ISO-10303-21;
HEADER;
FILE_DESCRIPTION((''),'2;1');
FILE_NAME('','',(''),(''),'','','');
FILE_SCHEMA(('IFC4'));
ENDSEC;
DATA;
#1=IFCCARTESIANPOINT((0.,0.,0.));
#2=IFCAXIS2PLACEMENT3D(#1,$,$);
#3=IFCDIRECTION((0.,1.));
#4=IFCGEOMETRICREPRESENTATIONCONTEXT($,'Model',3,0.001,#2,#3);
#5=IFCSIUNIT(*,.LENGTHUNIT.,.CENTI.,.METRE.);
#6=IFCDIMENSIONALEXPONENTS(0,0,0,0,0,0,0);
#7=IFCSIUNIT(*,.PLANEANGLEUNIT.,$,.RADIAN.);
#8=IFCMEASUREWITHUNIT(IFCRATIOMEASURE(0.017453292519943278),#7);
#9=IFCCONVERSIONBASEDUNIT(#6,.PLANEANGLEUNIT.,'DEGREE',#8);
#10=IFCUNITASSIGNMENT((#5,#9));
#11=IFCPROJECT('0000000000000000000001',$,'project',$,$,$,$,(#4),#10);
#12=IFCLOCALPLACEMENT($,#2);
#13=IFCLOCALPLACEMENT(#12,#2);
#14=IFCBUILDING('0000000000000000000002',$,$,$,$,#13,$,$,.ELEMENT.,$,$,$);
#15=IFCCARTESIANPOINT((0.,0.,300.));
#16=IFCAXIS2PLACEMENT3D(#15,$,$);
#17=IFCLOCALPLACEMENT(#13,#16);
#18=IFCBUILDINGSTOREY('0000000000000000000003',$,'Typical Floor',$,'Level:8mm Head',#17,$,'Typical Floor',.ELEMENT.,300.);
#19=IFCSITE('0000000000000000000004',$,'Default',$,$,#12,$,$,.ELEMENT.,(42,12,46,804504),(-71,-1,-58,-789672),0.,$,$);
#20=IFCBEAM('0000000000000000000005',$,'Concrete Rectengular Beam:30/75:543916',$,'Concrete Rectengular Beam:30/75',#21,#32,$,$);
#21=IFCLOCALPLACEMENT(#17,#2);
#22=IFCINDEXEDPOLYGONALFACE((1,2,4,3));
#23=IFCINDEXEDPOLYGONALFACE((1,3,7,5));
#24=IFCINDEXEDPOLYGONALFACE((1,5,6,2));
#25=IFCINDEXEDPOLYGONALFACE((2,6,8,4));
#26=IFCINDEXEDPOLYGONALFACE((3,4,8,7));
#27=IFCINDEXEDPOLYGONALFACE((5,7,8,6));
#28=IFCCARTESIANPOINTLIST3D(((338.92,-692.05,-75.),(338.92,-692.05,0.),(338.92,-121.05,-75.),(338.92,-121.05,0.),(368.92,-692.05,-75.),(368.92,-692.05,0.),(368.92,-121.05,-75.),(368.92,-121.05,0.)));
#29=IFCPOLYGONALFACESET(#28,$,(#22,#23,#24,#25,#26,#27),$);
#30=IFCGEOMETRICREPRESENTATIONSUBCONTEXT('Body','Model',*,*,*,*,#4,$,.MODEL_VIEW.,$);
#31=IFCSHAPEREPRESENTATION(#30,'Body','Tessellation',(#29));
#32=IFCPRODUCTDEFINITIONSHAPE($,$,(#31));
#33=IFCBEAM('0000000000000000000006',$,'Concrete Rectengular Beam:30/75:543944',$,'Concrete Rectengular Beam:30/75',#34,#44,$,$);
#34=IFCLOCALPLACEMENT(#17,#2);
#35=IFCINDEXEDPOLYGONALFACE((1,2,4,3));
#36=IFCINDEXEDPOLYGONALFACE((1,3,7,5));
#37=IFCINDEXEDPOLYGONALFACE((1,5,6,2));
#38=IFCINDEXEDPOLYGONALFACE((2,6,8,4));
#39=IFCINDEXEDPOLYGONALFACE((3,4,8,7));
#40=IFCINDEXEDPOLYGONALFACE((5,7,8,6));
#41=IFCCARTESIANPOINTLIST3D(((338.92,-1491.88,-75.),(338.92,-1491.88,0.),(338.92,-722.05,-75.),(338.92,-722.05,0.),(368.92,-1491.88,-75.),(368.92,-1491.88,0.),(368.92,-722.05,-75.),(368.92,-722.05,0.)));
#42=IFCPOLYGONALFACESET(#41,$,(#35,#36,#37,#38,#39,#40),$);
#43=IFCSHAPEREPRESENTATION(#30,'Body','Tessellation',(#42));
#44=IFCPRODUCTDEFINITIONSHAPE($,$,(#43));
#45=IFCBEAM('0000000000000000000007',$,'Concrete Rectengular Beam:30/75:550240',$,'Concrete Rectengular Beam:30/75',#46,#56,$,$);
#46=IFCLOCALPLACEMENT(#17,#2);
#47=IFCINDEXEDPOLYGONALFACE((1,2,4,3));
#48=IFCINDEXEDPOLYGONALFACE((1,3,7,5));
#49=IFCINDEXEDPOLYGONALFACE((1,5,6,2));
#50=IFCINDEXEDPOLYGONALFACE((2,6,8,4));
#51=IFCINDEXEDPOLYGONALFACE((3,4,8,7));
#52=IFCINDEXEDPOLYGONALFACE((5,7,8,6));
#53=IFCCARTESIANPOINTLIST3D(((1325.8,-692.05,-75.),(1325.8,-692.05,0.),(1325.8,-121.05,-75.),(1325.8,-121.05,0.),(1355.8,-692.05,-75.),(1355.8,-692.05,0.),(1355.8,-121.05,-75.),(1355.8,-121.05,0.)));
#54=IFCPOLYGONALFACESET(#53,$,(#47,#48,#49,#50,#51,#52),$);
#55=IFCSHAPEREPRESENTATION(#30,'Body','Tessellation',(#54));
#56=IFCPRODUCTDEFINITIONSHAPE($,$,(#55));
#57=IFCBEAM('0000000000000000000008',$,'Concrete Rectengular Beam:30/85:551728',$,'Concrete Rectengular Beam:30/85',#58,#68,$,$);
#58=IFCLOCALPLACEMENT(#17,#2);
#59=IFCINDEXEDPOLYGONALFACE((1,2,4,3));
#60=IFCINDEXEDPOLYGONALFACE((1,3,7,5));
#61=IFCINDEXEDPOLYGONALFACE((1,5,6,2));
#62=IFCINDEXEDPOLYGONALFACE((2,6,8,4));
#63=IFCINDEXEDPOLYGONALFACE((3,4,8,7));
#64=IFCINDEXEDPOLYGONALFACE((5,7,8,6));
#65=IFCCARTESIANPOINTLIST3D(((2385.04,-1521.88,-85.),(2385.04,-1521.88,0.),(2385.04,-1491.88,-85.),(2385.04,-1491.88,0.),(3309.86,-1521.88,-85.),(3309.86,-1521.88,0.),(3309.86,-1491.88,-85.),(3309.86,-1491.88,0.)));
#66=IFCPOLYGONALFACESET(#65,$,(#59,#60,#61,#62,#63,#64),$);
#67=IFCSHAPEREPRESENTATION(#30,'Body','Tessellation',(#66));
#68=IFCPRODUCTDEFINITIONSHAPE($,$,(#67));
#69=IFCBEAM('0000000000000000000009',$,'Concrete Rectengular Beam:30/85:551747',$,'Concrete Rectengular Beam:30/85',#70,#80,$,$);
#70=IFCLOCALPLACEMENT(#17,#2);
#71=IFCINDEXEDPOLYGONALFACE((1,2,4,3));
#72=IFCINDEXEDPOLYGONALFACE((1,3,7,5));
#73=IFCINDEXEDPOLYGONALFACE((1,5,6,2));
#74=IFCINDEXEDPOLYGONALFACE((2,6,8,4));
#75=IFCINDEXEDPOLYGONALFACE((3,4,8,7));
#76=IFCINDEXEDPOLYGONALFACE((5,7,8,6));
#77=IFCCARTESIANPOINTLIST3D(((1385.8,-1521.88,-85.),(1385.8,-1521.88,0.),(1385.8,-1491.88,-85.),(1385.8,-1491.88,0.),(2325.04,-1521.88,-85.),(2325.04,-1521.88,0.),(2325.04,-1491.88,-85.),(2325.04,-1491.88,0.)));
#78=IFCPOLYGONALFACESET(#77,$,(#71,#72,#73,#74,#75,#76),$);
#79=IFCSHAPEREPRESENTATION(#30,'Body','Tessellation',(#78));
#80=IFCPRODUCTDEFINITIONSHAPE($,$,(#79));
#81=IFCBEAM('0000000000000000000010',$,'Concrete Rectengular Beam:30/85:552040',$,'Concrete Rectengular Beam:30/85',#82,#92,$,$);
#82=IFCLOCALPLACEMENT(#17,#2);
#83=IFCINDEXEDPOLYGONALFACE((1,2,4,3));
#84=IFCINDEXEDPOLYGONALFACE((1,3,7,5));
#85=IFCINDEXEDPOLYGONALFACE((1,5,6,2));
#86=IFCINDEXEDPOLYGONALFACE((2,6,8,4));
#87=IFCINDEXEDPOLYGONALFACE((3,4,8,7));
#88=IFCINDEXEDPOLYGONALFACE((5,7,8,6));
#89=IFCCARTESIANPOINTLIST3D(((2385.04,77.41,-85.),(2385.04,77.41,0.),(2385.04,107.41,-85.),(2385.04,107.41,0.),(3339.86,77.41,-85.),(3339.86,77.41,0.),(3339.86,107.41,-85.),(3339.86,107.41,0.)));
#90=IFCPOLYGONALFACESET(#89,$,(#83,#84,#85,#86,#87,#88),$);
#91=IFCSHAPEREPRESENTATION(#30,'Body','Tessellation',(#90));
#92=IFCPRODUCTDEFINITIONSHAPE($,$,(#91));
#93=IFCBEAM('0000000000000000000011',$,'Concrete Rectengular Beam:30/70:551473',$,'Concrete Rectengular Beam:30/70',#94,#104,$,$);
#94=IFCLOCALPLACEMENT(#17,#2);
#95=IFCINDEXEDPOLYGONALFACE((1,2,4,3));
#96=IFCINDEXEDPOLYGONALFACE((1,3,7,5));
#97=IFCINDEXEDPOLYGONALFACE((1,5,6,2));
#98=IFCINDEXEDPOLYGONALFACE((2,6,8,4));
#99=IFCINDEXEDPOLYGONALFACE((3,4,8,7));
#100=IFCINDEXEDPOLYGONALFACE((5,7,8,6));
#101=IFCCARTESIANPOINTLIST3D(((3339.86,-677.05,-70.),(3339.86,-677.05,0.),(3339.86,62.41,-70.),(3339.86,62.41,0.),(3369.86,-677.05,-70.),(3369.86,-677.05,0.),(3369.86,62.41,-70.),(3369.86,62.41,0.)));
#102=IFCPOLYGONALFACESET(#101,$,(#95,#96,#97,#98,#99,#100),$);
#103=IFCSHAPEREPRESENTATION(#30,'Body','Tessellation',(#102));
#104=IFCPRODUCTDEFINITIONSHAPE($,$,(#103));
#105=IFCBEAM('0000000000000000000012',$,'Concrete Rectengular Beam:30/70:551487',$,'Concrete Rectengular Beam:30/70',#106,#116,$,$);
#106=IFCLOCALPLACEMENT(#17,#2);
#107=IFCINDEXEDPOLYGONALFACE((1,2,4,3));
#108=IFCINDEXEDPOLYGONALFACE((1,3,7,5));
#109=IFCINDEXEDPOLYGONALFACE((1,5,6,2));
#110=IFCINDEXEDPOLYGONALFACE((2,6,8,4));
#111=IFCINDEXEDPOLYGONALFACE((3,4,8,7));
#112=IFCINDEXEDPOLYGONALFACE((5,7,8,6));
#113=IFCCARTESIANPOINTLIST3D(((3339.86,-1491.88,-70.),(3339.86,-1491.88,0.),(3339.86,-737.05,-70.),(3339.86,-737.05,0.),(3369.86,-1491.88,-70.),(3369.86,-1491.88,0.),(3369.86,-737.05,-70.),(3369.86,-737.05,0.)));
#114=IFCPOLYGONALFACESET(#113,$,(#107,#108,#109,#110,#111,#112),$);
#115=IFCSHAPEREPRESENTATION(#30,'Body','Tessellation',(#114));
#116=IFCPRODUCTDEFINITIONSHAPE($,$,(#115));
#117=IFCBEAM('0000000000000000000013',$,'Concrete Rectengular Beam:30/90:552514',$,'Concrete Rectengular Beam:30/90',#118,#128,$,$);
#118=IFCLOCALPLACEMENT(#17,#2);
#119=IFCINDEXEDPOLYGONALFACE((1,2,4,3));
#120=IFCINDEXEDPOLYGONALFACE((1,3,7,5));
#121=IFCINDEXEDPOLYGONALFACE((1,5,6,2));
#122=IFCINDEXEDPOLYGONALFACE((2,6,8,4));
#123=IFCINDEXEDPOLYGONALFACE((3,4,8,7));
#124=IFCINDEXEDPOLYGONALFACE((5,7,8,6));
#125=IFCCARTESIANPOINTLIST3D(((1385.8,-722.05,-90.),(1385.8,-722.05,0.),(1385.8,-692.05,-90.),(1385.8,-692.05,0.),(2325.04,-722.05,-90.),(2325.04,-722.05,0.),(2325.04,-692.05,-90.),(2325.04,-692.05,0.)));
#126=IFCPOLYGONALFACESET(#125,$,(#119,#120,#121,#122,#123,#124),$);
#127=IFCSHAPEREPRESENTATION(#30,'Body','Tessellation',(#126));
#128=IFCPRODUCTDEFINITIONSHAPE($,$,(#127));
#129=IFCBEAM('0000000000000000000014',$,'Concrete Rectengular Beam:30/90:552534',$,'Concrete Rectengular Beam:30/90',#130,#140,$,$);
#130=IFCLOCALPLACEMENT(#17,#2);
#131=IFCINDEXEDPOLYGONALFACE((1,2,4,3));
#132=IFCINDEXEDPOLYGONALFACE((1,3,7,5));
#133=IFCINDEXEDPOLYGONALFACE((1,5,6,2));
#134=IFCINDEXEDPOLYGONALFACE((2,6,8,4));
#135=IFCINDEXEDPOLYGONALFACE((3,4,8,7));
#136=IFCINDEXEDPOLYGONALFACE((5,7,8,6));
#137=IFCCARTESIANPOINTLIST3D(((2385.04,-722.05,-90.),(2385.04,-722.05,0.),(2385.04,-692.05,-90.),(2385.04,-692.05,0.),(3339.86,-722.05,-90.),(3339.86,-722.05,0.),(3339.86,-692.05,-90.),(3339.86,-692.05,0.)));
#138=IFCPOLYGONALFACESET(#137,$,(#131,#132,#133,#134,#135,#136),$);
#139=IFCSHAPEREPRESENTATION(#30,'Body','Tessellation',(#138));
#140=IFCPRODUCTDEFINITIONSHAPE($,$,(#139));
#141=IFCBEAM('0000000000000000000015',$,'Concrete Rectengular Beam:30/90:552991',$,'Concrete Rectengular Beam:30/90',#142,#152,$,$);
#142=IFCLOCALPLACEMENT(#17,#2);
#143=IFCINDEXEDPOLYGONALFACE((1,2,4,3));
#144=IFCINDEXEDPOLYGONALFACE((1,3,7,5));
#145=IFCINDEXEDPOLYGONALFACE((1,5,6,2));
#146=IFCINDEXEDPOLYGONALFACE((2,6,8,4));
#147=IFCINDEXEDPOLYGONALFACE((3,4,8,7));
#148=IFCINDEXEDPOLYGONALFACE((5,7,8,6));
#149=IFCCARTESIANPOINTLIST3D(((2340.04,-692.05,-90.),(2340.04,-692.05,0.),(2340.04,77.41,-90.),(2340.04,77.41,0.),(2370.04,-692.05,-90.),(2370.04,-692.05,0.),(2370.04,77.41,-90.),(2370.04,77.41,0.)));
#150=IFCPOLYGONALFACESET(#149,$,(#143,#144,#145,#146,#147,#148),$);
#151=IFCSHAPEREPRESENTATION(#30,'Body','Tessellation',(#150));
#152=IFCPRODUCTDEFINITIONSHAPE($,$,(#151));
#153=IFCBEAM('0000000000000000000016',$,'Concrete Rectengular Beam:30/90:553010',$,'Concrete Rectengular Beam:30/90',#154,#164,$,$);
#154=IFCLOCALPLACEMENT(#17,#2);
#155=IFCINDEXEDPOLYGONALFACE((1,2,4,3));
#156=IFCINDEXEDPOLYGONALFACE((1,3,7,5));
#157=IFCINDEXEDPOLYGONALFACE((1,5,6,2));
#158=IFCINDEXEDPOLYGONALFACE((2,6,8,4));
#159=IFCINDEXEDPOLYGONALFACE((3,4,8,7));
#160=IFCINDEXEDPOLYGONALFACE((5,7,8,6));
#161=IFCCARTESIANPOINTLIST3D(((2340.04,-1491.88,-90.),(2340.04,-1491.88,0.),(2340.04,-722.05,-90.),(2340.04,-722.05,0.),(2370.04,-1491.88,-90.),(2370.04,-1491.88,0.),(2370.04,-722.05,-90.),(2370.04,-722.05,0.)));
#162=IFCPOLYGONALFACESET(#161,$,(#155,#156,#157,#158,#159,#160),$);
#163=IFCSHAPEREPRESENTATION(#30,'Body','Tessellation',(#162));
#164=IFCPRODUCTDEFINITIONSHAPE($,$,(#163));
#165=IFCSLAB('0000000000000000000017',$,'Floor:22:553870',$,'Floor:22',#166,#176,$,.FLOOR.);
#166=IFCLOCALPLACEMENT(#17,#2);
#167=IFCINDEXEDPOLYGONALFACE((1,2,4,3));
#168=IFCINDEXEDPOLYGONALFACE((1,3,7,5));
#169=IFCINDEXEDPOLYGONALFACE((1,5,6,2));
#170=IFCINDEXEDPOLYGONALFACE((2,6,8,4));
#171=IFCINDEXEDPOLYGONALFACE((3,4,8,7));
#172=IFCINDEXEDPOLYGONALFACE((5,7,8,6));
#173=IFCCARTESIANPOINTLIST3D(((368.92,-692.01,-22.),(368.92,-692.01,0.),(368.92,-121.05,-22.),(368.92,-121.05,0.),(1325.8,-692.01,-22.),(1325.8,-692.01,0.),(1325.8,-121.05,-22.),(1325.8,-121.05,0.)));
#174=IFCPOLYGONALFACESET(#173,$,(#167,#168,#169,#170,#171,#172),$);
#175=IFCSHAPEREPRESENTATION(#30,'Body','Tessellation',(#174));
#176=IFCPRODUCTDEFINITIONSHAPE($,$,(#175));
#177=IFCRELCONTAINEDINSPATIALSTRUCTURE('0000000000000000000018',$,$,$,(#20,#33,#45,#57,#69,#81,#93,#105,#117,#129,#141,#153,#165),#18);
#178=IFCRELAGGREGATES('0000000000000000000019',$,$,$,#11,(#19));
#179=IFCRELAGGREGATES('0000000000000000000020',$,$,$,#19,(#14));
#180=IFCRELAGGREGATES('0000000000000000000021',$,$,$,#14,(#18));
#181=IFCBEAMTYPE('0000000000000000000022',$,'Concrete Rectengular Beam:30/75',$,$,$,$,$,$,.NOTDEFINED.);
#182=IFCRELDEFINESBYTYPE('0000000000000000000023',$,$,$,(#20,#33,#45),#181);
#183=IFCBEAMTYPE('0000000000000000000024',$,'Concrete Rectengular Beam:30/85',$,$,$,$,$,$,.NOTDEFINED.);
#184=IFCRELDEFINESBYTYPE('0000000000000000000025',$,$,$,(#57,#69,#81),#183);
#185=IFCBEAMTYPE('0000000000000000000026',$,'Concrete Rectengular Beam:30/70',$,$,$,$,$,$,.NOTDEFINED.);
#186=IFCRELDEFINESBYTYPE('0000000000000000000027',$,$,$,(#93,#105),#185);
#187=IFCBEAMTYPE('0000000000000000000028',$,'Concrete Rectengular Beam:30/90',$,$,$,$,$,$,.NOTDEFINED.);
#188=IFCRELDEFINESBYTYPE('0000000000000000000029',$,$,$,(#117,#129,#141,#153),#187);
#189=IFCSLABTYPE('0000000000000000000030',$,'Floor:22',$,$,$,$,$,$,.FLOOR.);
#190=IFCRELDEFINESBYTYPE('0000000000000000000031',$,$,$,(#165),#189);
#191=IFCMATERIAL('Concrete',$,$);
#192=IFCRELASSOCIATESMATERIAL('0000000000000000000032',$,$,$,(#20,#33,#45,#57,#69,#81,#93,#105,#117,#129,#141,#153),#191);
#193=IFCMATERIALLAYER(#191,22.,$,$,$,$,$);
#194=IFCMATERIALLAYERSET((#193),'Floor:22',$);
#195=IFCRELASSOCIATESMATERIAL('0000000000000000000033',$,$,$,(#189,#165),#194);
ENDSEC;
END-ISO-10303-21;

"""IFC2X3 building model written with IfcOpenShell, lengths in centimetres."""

from ifc_helpers import new_model, entity, si_unit, converted_unit, direction, frame, frame_2d, origin, place, context, subcontext, project, spatial, rectangle, extrude, material, layer, layer_set, layer_usage, type_object, element, save


model = new_model("IFC2X3")

# Units and contexts
model_context = context("Model", 3, precision=0.001, world=origin(), true_north=direction((0.0, 1.0)))
body_context = subcontext(model_context, "Body", "Model", "MODEL_VIEW")
ifc_project = project(units=[si_unit("LENGTHUNIT", "METRE", prefix="CENTI"), converted_unit("PLANEANGLEUNIT", "DEGREE", entity("IfcRatioMeasure", 0.017453292519943278), si_unit("PLANEANGLEUNIT", "RADIAN"), dimensions=[0, 0, 0, 0, 0, 0, 0])], contexts=[model_context])

# Site, building, storey
site_placement = place(None, origin())
site = spatial("IfcSite", under=ifc_project, at=site_placement, Name="Default", CompositionType="ELEMENT", RefLatitude=(42, 12, 46, 804504), RefLongitude=(-71, -1, -58, -789672), RefElevation=0.0)
building_placement = place(site_placement, origin())
building = spatial("IfcBuilding", under=site, at=building_placement, CompositionType="ELEMENT")
storey_placement = place(building_placement, frame((0.0, 0.0, 300.0)))
storey = spatial("IfcBuildingStorey", under=building, at=storey_placement, Name="Typical Floor", ObjectType="Level:8mm Head", LongName="Typical Floor", CompositionType="ELEMENT", Elevation=300.0)

# Beams
ifc_material = material(Name="Concrete")
beam_type_1 = type_object("IfcBeamType", Name="Concrete Rectengular Beam:30/75", PredefinedType="NOTDEFINED")
beam_1_placement = place(storey_placement, frame((353.92, -707.05, 0.0), z_axis=(0.0, 0.0, 1.0), x_axis=(0.0, 1.0, 0.0)))
element("IfcBeam", 1, at=beam_1_placement, inside=storey, type_object=beam_type_1, material=ifc_material, Name="Concrete Rectengular Beam:30/75:543916", ObjectType="Concrete Rectengular Beam:30/75", context=body_context, shape_type="SweptSolid", body=[
    extrude(rectangle(XDim=75.0, YDim=30.0, at=frame_2d((0.0, 0.0), x_axis=(1.0, 0.0))), frame((15.0, 0.0, -37.5), z_axis=(1.0, 0.0, 0.0), x_axis=(0.0, 0.0, -1.0)), (0.0, 0.0, 1.0), 571.0),
])
beam_2_placement = place(storey_placement, frame((353.92, -707.05, 0.0), z_axis=(0.0, 0.0, 1.0), x_axis=(0.0, -1.0, 0.0)))
element("IfcBeam", 2, at=beam_2_placement, inside=storey, type_object=beam_type_1, material=ifc_material, Name="Concrete Rectengular Beam:30/75:543944", ObjectType="Concrete Rectengular Beam:30/75", context=body_context, shape_type="SweptSolid", body=[
    extrude(rectangle(XDim=75.0, YDim=30.0, at=frame_2d((0.0, 0.0), x_axis=(1.0, 0.0))), frame((15.0, 0.0, -37.5), z_axis=(1.0, 0.0, 0.0), x_axis=(0.0, 0.0, -1.0)), (0.0, 0.0, 1.0), 769.83),
])
beam_3_placement = place(storey_placement, frame((1340.8, -707.05, 0.0), z_axis=(0.0, 0.0, 1.0), x_axis=(0.0, 1.0, 0.0)))
element("IfcBeam", 3, at=beam_3_placement, inside=storey, type_object=beam_type_1, material=ifc_material, Name="Concrete Rectengular Beam:30/75:550240", ObjectType="Concrete Rectengular Beam:30/75", context=body_context, shape_type="SweptSolid", body=[
    extrude(rectangle(XDim=75.0, YDim=30.0, at=frame_2d((0.0, 0.0), x_axis=(1.0, 0.0))), frame((15.0, 0.0, -37.5), z_axis=(1.0, 0.0, 0.0), x_axis=(0.0, 0.0, -1.0)), (0.0, 0.0, 1.0), 571.0),
])
beam_type_2 = type_object("IfcBeamType", Name="Concrete Rectengular Beam:30/85", PredefinedType="NOTDEFINED")
beam_4_placement = place(storey_placement, frame((3339.86, -1506.88, 0.0), z_axis=(0.0, 0.0, 1.0), x_axis=(-1.0, 0.0, 0.0)))
element("IfcBeam", 4, at=beam_4_placement, inside=storey, type_object=beam_type_2, material=ifc_material, Name="Concrete Rectengular Beam:30/85:551728", ObjectType="Concrete Rectengular Beam:30/85", context=body_context, shape_type="SweptSolid", body=[
    extrude(rectangle(XDim=85.0, YDim=30.0, at=frame_2d((0.0, 0.0), x_axis=(1.0, 0.0))), frame((30.0, 0.0, -42.5), z_axis=(1.0, 0.0, 0.0), x_axis=(0.0, 0.0, -1.0)), (0.0, 0.0, 1.0), 924.83),
])
beam_5_placement = place(storey_placement, frame((2355.04, -1506.88, 0.0), z_axis=(0.0, 0.0, 1.0), x_axis=(-1.0, 0.0, 0.0)))
element("IfcBeam", 5, at=beam_5_placement, inside=storey, type_object=beam_type_2, material=ifc_material, Name="Concrete Rectengular Beam:30/85:551747", ObjectType="Concrete Rectengular Beam:30/85", context=body_context, shape_type="SweptSolid", body=[
    extrude(rectangle(XDim=85.0, YDim=30.0, at=frame_2d((0.0, 0.0), x_axis=(1.0, 0.0))), frame((30.0, 0.0, -42.5), z_axis=(1.0, 0.0, 0.0), x_axis=(0.0, 0.0, -1.0)), (0.0, 0.0, 1.0), 939.24),
])
beam_6_placement = place(storey_placement, frame((3354.86, 92.41, 0.0), z_axis=(0.0, 0.0, 1.0), x_axis=(-1.0, 0.0, 0.0)))
element("IfcBeam", 6, at=beam_6_placement, inside=storey, type_object=beam_type_2, material=ifc_material, Name="Concrete Rectengular Beam:30/85:552040", ObjectType="Concrete Rectengular Beam:30/85", context=body_context, shape_type="SweptSolid", body=[
    extrude(rectangle(XDim=85.0, YDim=30.0, at=frame_2d((0.0, 0.0), x_axis=(1.0, 0.0))), frame((15.0, 0.0, -42.5), z_axis=(1.0, 0.0, 0.0), x_axis=(0.0, 0.0, -1.0)), (0.0, 0.0, 1.0), 954.83),
])
beam_type_3 = type_object("IfcBeamType", Name="Concrete Rectengular Beam:30/70", PredefinedType="NOTDEFINED")
beam_7_placement = place(storey_placement, frame((3369.86, 92.41, 0.0), z_axis=(0.0, 0.0, 1.0), x_axis=(0.0, -1.0, 0.0)))
element("IfcBeam", 7, at=beam_7_placement, inside=storey, type_object=beam_type_3, material=ifc_material, Name="Concrete Rectengular Beam:30/70:551473", ObjectType="Concrete Rectengular Beam:30/70", context=body_context, shape_type="SweptSolid", body=[
    extrude(rectangle(XDim=70.0, YDim=30.0, at=frame_2d((0.0, 0.0), x_axis=(1.0, 0.0))), frame((30.0, -15.0, -35.0), z_axis=(1.0, 0.0, 0.0), x_axis=(0.0, 0.0, -1.0)), (0.0, 0.0, 1.0), 739.46),
])
beam_8_placement = place(storey_placement, frame((3369.86, -707.05, 0.0), z_axis=(0.0, 0.0, 1.0), x_axis=(0.0, -1.0, 0.0)))
element("IfcBeam", 8, at=beam_8_placement, inside=storey, type_object=beam_type_3, material=ifc_material, Name="Concrete Rectengular Beam:30/70:551487", ObjectType="Concrete Rectengular Beam:30/70", context=body_context, shape_type="SweptSolid", body=[
    extrude(rectangle(XDim=70.0, YDim=30.0, at=frame_2d((0.0, 0.0), x_axis=(1.0, 0.0))), frame((30.0, -15.0, -35.0), z_axis=(1.0, 0.0, 0.0), x_axis=(0.0, 0.0, -1.0)), (0.0, 0.0, 1.0), 754.83),
])
beam_type_4 = type_object("IfcBeamType", Name="Concrete Rectengular Beam:30/90", PredefinedType="NOTDEFINED")
beam_9_placement = place(storey_placement, frame((1355.8, -707.05, 0.0)))
element("IfcBeam", 9, at=beam_9_placement, inside=storey, type_object=beam_type_4, material=ifc_material, Name="Concrete Rectengular Beam:30/90:552514", ObjectType="Concrete Rectengular Beam:30/90", context=body_context, shape_type="SweptSolid", body=[
    extrude(rectangle(XDim=90.0, YDim=30.0, at=frame_2d((0.0, 0.0), x_axis=(1.0, 0.0))), frame((30.0, 0.0, -45.0), z_axis=(1.0, 0.0, 0.0), x_axis=(0.0, 0.0, -1.0)), (0.0, 0.0, 1.0), 939.24),
])
beam_10_placement = place(storey_placement, frame((2355.04, -707.05, 0.0)))
element("IfcBeam", 10, at=beam_10_placement, inside=storey, type_object=beam_type_4, material=ifc_material, Name="Concrete Rectengular Beam:30/90:552534", ObjectType="Concrete Rectengular Beam:30/90", context=body_context, shape_type="SweptSolid", body=[
    extrude(rectangle(XDim=90.0, YDim=30.0, at=frame_2d((0.0, 0.0), x_axis=(1.0, 0.0))), frame((30.0, 0.0, -45.0), z_axis=(1.0, 0.0, 0.0), x_axis=(0.0, 0.0, -1.0)), (0.0, 0.0, 1.0), 954.83),
])
beam_11_placement = place(storey_placement, frame((2355.04, 92.41, 0.0), z_axis=(0.0, 0.0, 1.0), x_axis=(0.0, -1.0, 0.0)))
element("IfcBeam", 11, at=beam_11_placement, inside=storey, type_object=beam_type_4, material=ifc_material, Name="Concrete Rectengular Beam:30/90:552991", ObjectType="Concrete Rectengular Beam:30/90", context=body_context, shape_type="SweptSolid", body=[
    extrude(rectangle(XDim=90.0, YDim=30.0, at=frame_2d((0.0, 0.0), x_axis=(1.0, 0.0))), frame((15.0, 0.0, -45.0), z_axis=(1.0, 0.0, 0.0), x_axis=(0.0, 0.0, -1.0)), (0.0, 0.0, 1.0), 769.46),
])
beam_12_placement = place(storey_placement, frame((2355.04, -707.05, 0.0), z_axis=(0.0, 0.0, 1.0), x_axis=(0.0, -1.0, 0.0)))
element("IfcBeam", 12, at=beam_12_placement, inside=storey, type_object=beam_type_4, material=ifc_material, Name="Concrete Rectengular Beam:30/90:553010", ObjectType="Concrete Rectengular Beam:30/90", context=body_context, shape_type="SweptSolid", body=[
    extrude(rectangle(XDim=90.0, YDim=30.0, at=frame_2d((0.0, 0.0), x_axis=(1.0, 0.0))), frame((15.0, 0.0, -45.0), z_axis=(1.0, 0.0, 0.0), x_axis=(0.0, 0.0, -1.0)), (0.0, 0.0, 1.0), 769.83),
])

# Slab
ifc_layer = layer(ifc_material, 22.0)
ifc_layer_set = layer_set([ifc_layer], Name="Floor:22")
ifc_layer_usage_1 = layer_usage(ifc_layer_set, "AXIS3", "POSITIVE", 0.0)
slab_type_1 = type_object("IfcSlabType", Name="Floor:22", PredefinedType="FLOOR", material=ifc_layer_set)
slab_1_placement = place(storey_placement, origin())
element("IfcSlab", 13, at=slab_1_placement, inside=storey, type_object=slab_type_1, material=ifc_layer_usage_1, Name="Floor:22:553870", ObjectType="Floor:22", PredefinedType="FLOOR", context=body_context, shape_type="SweptSolid", body=[
    extrude(rectangle(XDim=570.97, YDim=956.88, at=frame_2d((0.0, 0.0), x_axis=(1.0, 0.0))), frame((847.36, -406.53, 0.0), z_axis=(0.0, 0.0, -1.0), x_axis=(0.0, 1.0, 0.0)), (0.0, 0.0, 1.0), 22.0),
])

save(model, "model.ifc")
